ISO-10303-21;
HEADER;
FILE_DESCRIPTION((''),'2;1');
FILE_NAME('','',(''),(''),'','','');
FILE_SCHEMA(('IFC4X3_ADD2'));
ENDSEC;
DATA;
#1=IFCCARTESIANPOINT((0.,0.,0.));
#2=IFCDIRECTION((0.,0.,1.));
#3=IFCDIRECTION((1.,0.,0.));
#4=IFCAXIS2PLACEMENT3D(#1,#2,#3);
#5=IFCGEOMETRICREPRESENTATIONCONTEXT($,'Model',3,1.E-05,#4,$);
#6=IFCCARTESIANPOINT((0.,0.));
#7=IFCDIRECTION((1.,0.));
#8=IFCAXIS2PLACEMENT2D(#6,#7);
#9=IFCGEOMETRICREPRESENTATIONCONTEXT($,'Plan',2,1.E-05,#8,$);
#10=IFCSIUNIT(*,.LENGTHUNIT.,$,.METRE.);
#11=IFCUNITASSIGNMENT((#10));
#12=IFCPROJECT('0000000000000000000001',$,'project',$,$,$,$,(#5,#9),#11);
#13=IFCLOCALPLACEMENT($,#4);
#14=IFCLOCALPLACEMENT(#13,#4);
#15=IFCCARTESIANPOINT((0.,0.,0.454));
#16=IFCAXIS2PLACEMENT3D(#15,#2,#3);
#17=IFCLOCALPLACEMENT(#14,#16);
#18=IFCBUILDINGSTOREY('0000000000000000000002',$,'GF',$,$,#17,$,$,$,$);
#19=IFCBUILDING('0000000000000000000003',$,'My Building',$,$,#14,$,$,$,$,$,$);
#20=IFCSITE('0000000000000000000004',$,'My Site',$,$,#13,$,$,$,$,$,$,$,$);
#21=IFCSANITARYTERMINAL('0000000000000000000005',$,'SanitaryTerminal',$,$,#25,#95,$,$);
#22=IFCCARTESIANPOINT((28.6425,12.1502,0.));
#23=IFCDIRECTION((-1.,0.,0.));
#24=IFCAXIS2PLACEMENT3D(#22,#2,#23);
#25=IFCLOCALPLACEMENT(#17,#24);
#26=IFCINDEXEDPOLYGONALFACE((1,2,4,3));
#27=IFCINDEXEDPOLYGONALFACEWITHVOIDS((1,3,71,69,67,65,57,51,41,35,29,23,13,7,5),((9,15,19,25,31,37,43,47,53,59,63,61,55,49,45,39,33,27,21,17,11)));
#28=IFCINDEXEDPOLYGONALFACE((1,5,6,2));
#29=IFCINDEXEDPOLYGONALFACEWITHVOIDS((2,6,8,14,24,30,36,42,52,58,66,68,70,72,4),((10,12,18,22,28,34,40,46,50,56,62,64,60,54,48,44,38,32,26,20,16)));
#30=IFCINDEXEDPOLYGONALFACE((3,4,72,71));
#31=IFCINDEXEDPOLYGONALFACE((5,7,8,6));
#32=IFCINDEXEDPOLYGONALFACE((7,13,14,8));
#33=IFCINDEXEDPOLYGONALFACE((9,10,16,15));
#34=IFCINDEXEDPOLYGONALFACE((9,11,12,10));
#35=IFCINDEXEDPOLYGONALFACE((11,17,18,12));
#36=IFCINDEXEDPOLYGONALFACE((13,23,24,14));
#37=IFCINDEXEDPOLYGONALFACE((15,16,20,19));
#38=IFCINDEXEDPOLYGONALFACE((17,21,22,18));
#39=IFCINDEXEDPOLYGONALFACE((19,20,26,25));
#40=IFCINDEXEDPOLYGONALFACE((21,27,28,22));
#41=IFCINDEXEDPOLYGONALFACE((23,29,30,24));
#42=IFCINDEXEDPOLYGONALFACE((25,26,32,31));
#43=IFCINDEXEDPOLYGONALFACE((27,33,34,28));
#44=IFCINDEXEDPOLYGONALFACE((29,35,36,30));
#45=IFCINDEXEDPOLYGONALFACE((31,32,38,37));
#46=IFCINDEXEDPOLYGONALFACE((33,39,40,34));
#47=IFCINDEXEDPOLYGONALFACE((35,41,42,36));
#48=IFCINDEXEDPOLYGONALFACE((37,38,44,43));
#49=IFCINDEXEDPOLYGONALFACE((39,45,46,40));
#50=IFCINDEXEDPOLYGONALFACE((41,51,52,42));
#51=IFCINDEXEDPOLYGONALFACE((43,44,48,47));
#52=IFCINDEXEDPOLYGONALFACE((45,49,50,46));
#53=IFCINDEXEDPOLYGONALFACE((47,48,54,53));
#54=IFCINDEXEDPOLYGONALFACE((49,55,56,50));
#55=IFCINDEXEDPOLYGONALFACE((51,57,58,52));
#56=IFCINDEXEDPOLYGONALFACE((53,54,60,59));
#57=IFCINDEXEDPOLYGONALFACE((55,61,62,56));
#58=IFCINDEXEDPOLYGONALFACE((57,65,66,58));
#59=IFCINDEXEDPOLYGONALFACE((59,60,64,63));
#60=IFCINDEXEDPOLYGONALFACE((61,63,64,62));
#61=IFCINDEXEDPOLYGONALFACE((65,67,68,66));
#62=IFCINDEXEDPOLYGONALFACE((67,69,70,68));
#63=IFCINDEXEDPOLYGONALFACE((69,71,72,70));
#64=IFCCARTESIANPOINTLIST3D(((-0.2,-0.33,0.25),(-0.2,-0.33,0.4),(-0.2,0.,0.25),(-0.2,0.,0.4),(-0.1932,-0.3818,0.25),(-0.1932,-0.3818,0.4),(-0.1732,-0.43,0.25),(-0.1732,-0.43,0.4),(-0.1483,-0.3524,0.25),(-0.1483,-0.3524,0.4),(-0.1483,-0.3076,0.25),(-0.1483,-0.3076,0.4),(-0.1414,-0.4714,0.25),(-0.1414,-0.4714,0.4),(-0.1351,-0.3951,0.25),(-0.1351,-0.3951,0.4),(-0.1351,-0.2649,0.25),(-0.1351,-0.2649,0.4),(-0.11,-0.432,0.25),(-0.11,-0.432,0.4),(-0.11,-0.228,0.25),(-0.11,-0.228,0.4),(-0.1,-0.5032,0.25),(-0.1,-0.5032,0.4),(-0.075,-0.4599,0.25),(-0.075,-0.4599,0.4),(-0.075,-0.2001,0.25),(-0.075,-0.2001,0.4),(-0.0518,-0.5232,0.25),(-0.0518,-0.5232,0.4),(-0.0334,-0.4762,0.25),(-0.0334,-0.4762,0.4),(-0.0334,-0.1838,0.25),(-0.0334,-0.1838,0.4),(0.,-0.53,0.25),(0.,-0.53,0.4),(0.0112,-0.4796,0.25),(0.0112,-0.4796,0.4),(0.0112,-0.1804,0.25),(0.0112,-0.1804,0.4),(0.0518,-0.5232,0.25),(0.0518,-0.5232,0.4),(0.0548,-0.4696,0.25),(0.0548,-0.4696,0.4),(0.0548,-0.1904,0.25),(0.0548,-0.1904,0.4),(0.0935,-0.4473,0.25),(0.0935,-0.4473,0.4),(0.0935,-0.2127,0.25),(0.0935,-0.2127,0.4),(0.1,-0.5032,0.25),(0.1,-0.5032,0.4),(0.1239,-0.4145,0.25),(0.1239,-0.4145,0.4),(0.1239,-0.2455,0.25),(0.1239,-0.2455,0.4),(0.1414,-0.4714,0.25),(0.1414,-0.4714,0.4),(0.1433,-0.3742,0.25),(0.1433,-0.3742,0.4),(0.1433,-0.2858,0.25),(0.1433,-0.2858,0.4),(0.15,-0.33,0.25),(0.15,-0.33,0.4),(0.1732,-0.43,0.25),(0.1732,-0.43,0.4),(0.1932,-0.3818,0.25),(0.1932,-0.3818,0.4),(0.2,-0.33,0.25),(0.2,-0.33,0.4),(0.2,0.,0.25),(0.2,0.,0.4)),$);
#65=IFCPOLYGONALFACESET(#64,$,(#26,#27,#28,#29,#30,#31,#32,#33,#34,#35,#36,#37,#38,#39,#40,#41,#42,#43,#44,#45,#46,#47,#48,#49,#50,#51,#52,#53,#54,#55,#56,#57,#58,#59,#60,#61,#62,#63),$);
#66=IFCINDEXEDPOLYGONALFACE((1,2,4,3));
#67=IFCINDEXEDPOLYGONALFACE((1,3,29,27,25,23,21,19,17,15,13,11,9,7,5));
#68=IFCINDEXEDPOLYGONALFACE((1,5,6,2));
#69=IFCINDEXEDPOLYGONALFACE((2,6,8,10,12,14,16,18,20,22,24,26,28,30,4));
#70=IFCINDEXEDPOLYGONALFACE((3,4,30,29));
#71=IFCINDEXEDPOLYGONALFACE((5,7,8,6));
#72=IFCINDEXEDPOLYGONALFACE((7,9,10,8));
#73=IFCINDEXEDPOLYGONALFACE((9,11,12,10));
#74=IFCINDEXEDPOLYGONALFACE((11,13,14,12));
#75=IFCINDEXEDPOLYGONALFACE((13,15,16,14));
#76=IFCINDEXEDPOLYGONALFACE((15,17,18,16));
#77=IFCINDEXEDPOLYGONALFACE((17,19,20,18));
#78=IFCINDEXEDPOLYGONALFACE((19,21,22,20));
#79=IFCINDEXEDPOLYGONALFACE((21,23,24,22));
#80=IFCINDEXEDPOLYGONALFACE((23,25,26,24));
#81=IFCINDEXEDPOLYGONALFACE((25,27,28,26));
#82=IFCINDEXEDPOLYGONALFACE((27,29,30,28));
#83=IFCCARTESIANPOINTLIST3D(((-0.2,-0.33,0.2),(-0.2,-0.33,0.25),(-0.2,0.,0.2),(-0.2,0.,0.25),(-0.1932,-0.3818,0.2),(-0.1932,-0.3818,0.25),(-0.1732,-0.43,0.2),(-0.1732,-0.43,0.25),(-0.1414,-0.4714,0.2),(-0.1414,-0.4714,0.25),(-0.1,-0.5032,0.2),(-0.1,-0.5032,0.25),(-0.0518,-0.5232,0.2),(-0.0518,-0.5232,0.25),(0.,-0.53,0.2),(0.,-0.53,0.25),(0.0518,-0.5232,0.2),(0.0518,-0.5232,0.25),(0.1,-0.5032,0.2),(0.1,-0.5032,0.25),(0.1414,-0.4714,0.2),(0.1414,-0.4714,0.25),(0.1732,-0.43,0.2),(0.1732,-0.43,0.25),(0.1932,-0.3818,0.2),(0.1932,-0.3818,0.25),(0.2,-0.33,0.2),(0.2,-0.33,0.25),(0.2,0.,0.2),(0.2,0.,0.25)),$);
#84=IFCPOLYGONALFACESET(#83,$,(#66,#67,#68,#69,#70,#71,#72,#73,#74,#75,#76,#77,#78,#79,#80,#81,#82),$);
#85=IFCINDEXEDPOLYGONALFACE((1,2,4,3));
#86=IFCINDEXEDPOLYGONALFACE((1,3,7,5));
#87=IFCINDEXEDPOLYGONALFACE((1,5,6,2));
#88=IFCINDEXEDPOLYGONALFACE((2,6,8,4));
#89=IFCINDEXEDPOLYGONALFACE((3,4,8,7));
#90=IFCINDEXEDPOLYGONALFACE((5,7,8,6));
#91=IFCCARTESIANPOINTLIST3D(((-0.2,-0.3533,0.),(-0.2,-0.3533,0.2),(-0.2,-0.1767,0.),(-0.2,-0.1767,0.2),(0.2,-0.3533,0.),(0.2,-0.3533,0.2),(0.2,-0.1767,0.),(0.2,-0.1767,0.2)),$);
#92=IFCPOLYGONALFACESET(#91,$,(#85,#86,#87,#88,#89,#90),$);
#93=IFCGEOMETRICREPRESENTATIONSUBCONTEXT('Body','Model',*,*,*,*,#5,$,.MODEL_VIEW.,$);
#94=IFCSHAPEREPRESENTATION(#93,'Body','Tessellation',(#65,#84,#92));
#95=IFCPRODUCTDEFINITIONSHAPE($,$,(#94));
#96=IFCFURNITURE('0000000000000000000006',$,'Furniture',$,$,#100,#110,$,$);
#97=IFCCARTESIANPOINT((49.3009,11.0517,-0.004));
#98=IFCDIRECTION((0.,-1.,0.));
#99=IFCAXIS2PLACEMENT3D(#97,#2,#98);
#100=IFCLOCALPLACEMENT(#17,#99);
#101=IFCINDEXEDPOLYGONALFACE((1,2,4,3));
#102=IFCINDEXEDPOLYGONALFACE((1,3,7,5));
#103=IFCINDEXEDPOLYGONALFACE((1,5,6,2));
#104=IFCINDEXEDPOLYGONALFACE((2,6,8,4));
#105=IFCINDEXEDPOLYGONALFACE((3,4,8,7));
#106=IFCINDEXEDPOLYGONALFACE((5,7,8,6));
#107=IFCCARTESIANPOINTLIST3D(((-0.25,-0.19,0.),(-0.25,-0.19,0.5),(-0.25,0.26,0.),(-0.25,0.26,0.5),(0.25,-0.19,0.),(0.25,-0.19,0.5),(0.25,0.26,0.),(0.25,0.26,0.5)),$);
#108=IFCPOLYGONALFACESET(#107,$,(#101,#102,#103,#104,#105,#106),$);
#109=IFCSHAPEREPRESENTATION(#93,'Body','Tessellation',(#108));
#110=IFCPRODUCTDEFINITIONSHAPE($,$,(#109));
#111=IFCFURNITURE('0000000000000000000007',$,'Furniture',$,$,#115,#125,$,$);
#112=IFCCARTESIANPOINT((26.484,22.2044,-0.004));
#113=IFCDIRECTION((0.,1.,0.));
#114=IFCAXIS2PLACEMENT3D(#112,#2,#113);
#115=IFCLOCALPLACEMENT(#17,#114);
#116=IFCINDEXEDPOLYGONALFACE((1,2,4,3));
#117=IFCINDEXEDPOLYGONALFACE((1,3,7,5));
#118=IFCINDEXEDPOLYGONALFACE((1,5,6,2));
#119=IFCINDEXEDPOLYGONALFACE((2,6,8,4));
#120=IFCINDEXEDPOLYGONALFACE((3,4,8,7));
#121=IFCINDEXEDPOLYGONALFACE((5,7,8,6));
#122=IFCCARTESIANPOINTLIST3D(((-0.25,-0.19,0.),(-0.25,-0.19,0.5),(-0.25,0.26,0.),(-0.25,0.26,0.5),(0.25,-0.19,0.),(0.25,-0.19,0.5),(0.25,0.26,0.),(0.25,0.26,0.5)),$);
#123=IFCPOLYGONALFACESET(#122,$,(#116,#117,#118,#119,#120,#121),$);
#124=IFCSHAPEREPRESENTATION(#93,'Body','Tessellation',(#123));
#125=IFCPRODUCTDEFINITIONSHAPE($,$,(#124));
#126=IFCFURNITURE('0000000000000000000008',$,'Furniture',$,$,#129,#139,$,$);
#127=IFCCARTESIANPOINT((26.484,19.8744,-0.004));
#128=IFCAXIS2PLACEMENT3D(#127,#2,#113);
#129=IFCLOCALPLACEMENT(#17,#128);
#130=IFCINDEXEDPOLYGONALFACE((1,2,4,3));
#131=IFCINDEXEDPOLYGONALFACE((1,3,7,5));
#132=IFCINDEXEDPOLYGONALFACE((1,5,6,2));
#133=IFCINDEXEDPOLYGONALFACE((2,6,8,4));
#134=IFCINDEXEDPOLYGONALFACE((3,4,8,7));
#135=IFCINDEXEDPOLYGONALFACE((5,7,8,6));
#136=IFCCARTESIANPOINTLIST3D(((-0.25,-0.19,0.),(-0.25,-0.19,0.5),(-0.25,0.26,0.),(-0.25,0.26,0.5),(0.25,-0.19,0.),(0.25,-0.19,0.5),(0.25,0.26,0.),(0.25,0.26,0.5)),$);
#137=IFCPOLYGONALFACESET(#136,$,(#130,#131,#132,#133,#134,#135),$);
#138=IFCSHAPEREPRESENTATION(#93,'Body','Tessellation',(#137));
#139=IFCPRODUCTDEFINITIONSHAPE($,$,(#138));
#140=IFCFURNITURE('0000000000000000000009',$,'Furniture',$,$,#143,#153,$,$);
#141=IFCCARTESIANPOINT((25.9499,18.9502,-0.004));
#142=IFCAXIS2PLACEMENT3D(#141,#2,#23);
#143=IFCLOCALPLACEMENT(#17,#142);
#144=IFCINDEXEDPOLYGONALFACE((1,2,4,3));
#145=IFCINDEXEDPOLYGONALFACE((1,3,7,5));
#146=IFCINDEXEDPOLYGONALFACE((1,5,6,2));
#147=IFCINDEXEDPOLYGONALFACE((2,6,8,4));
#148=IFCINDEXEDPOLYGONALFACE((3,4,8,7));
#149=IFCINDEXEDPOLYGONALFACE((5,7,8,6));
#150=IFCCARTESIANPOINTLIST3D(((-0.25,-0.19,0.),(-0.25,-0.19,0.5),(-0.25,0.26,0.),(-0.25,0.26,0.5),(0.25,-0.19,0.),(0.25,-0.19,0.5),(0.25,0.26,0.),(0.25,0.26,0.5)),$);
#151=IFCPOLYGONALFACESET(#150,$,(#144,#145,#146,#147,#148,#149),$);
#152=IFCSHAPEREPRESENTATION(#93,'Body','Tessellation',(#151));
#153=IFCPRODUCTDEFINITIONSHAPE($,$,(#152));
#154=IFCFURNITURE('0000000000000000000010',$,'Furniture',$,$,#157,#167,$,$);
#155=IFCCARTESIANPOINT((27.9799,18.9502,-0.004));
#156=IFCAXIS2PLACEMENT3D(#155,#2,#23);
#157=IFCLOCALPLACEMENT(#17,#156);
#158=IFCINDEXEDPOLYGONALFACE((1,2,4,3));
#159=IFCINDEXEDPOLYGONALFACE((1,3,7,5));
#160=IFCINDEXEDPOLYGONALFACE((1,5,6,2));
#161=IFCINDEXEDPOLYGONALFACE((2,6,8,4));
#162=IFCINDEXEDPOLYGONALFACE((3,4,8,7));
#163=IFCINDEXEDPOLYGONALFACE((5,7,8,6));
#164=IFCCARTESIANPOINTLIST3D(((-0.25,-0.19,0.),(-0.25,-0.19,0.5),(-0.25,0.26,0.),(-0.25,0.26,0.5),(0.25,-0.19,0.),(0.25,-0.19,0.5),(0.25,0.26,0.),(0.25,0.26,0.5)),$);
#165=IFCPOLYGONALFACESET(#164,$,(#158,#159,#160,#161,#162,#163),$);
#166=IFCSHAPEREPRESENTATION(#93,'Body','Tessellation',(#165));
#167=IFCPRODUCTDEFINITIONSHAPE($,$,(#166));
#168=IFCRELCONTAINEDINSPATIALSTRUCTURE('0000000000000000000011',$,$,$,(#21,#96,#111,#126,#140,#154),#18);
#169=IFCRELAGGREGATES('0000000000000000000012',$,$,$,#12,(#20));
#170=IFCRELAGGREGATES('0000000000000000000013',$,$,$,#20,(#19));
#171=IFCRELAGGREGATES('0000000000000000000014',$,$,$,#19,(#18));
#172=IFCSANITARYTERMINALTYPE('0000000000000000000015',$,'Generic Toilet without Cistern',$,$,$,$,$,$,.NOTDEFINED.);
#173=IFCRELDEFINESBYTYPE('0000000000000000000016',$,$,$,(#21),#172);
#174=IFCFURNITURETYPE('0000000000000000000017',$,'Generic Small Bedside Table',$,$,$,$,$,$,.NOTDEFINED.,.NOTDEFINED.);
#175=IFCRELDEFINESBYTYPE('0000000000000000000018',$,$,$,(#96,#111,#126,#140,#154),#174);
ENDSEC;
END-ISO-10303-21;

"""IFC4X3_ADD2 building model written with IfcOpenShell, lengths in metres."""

from ifc_helpers import new_model, entity, si_unit, frame, frame_2d, origin_with_axes, origin_2d_with_axis, place, context, subcontext, project, spatial, line, arc, indexed_curve, circle_curve, outline, extrude, shape, source, transform, mapped, type_object, type_shapes, element, save


model = new_model("IFC4X3_ADD2")

# Units and contexts
model_context = context("Model", 3, precision=1e-05, world=origin_with_axes())
plan_context = context("Plan", 2, precision=1e-05, world=origin_2d_with_axis())
body_context_1 = subcontext(model_context, "Body", "Model", "MODEL_VIEW")
body_context_2 = subcontext(plan_context, "Body", "Plan", "PLAN_VIEW")
ifc_project = project(units=[si_unit("LENGTHUNIT", "METRE")], contexts=[model_context, plan_context])

# Site, building, storey
site_placement = place(None, origin_with_axes())
site = spatial("IfcSite", under=ifc_project, at=site_placement, Name="My Site")
building_placement = place(site_placement, origin_with_axes())
building = spatial("IfcBuilding", under=site, at=building_placement, Name="My Building")
storey_placement = place(building_placement, frame((0.0, 0.0, 0.454), z_axis=(0.0, 0.0, 1.0), x_axis=(1.0, 0.0, 0.0)))
storey = spatial("IfcBuildingStorey", under=building, at=storey_placement, Name="GF")

# Sanitary terminal
sanitary_terminal_type_1 = type_object("IfcSanitaryTerminalType", Name="Generic Toilet without Cistern", PredefinedType="NOTDEFINED")
shared_shape_1 = source(origin_with_axes(), body_context_1, "Body", "SweptSolid", [
    extrude(outline(indexed_curve([(-0.2, 0.0), (0.2, 0.0), (0.2, -0.33), (0.1414, -0.4714), (0.0, -0.53), (-0.1414, -0.4714), (-0.2, -0.33)], segments=[line(1, 2), line(2, 3), arc(3, 4, 5), arc(5, 6, 7), line(7, 1)]), holes=[circle_curve(frame_2d((0.0, -0.33)), 0.15)]), frame((0.0, 0.0, 0.25), z_axis=(0.0, 0.0, 1.0), x_axis=(1.0, 0.0, 0.0)), (0.0, 0.0, 1.0), 0.15),
    extrude(outline(indexed_curve([(-0.2, 0.0), (0.2, 0.0), (0.2, -0.33), (0.1414, -0.4714), (0.0, -0.53), (-0.1414, -0.4714), (-0.2, -0.33)], segments=[line(1, 2), line(2, 3), arc(3, 4, 5), arc(5, 6, 7), line(7, 1)])), frame((0.0, 0.0, 0.2), z_axis=(0.0, 0.0, 1.0), x_axis=(1.0, 0.0, 0.0)), (0.0, 0.0, 1.0), 0.05),
    extrude(outline(indexed_curve([(-0.2, -0.1767), (0.2, -0.1767), (0.2, -0.3533), (-0.2, -0.3533)], segments=[line(1, 2, 3, 4, 1)])), origin_with_axes(), (0.0, 0.0, 1.0), 0.2),
])
shared_shape_2 = source(origin_with_axes(), body_context_2, "Body", "Annotation2D", [
    entity("IfcGeometricCurveSet", [entity("IfcIndexedPolyCurve", entity("IfcCartesianPointList2D", [[-0.1068, -0.124], [-0.0957, -0.1129], [-0.0804, -0.1088], [0.0804, -0.1088], [0.0957, -0.1129], [0.1068, -0.124], [0.1109, -0.1393], [0.1109, -0.3476], [0.1025, -0.3926], [0.0784, -0.4308], [0.0424, -0.4563], [0.0, -0.4652], [-0.0424, -0.4563], [-0.0784, -0.4308], [-0.1025, -0.3926], [-0.1109, -0.3476], [-0.1109, -0.1393]]), [entity("IfcLineIndex", [1, 2, 3, 4, 5, 6, 7, 8, 9, 10, 11, 12, 13, 14, 15, 16, 17, 1])]), entity("IfcIndexedPolyCurve", entity("IfcCartesianPointList2D", [[-0.1962, -0.2314], [-0.1848, -0.301], [-0.1764, -0.3339], [-0.1663, -0.3651], [-0.1546, -0.3944], [-0.1414, -0.4213], [-0.1269, -0.4458], [-0.1111, -0.4675], [-0.0943, -0.4862], [-0.0765, -0.5018], [-0.0581, -0.514], [-0.039, -0.5229], [-0.0196, -0.5282], [0.0, -0.53], [0.0196, -0.5282], [0.039, -0.5229], [0.0581, -0.514], [0.0765, -0.5018], [0.0943, -0.4862], [0.1111, -0.4675], [0.1269, -0.4458], [0.1414, -0.4213], [0.1546, -0.3944], [0.1663, -0.3651], [0.1764, -0.3339], [0.1848, -0.301], [0.1962, -0.2314], [0.2, -0.159], [0.1872, 0.0], [-0.1872, 0.0], [-0.2, -0.159]]), [entity("IfcLineIndex", [1, 2, 3, 4, 5, 6, 7, 8, 9, 10, 11, 12, 13, 14, 15, 16, 17, 18, 19, 20, 21, 22, 23, 24, 25, 26, 27, 28, 29, 30, 31, 1])])]),
])
type_shapes(sanitary_terminal_type_1, [shared_shape_1, shared_shape_2])
for number, where, z_axis, x_axis, name in (
    (1, (28.6425, 12.1502, 0.0), (0.0, 0.0, 1.0), (-1.0, 0.0, 0.0), "SanitaryTerminal"),
):
    element("IfcSanitaryTerminal", number, at=place(storey_placement, frame(where, z_axis=z_axis, x_axis=x_axis)), inside=storey, type_object=sanitary_terminal_type_1, Name=name, shapes=[
        shape(body_context_1, "Body", "MappedRepresentation", [mapped(shared_shape_1, transform((0.0, 0.0, 0.0), x_axis=(1.0, 0.0, 0.0), y_axis=(0.0, 1.0, 0.0), z_axis=(0.0, 0.0, 1.0), scale=1.0))]),
        shape(body_context_2, "Body", "MappedRepresentation", [mapped(shared_shape_2, transform((0.0, 0.0, 0.0), x_axis=(1.0, 0.0, 0.0), y_axis=(0.0, 1.0, 0.0), z_axis=(0.0, 0.0, 1.0), scale=1.0))]),
    ])

# Furniture
furniture_type_1 = type_object("IfcFurnitureType", Name="Generic Small Bedside Table", AssemblyPlace="NOTDEFINED", PredefinedType="NOTDEFINED")
shared_shape_3 = source(origin_with_axes(), body_context_1, "Body", "SweptSolid", [
    extrude(outline(indexed_curve([(0.5, 0.45), (0.5, 0.0), (0.0, 0.0), (0.0, 0.45)], segments=[line(4, 1), line(1, 2), line(2, 3), line(3, 4)], self_intersect=False)), frame((-0.25, -0.19, 0.0), z_axis=(0.0, 0.0, 1.0), x_axis=(1.0, 0.0, 0.0)), (0.0, 0.0, 1.0), 0.5),
])
shared_shape_4 = source(origin_with_axes(), body_context_2, "Body", "Annotation2D", [
    entity("IfcGeometricCurveSet", [entity("IfcIndexedPolyCurve", entity("IfcCartesianPointList2D", [[-0.25, -0.19], [0.25, -0.19], [0.25, 0.26], [-0.25, 0.26]]), [entity("IfcLineIndex", [1, 2]), entity("IfcLineIndex", [2, 3]), entity("IfcLineIndex", [3, 4]), entity("IfcLineIndex", [4, 1])])]),
])
type_shapes(furniture_type_1, [shared_shape_3, shared_shape_4])
for number, where, z_axis, x_axis, name in (
    (2, (49.3009, 11.0517, -0.004), (0.0, 0.0, 1.0), (0.0, -1.0, 0.0), "Furniture"),
    (3, (26.484, 22.2044, -0.004), (0.0, 0.0, 1.0), (0.0, 1.0, 0.0), "Furniture"),
    (4, (26.484, 19.8744, -0.004), (0.0, 0.0, 1.0), (0.0, 1.0, 0.0), "Furniture"),
    (5, (25.9499, 18.9502, -0.004), (0.0, 0.0, 1.0), (-1.0, 0.0, 0.0), "Furniture"),
    (6, (27.9799, 18.9502, -0.004), (0.0, 0.0, 1.0), (-1.0, 0.0, 0.0), "Furniture"),
):
    element("IfcFurniture", number, at=place(storey_placement, frame(where, z_axis=z_axis, x_axis=x_axis)), inside=storey, type_object=furniture_type_1, Name=name, shapes=[
        shape(body_context_1, "Body", "MappedRepresentation", [mapped(shared_shape_3, transform((0.0, 0.0, 0.0), x_axis=(1.0, 0.0, 0.0), y_axis=(0.0, 1.0, 0.0), z_axis=(0.0, 0.0, 1.0), scale=1.0))]),
        shape(body_context_2, "Body", "MappedRepresentation", [mapped(shared_shape_4, transform((0.0, 0.0, 0.0), x_axis=(1.0, 0.0, 0.0), y_axis=(0.0, 1.0, 0.0), z_axis=(0.0, 0.0, 1.0), scale=1.0))]),
    ])

save(model, "model.ifc")
